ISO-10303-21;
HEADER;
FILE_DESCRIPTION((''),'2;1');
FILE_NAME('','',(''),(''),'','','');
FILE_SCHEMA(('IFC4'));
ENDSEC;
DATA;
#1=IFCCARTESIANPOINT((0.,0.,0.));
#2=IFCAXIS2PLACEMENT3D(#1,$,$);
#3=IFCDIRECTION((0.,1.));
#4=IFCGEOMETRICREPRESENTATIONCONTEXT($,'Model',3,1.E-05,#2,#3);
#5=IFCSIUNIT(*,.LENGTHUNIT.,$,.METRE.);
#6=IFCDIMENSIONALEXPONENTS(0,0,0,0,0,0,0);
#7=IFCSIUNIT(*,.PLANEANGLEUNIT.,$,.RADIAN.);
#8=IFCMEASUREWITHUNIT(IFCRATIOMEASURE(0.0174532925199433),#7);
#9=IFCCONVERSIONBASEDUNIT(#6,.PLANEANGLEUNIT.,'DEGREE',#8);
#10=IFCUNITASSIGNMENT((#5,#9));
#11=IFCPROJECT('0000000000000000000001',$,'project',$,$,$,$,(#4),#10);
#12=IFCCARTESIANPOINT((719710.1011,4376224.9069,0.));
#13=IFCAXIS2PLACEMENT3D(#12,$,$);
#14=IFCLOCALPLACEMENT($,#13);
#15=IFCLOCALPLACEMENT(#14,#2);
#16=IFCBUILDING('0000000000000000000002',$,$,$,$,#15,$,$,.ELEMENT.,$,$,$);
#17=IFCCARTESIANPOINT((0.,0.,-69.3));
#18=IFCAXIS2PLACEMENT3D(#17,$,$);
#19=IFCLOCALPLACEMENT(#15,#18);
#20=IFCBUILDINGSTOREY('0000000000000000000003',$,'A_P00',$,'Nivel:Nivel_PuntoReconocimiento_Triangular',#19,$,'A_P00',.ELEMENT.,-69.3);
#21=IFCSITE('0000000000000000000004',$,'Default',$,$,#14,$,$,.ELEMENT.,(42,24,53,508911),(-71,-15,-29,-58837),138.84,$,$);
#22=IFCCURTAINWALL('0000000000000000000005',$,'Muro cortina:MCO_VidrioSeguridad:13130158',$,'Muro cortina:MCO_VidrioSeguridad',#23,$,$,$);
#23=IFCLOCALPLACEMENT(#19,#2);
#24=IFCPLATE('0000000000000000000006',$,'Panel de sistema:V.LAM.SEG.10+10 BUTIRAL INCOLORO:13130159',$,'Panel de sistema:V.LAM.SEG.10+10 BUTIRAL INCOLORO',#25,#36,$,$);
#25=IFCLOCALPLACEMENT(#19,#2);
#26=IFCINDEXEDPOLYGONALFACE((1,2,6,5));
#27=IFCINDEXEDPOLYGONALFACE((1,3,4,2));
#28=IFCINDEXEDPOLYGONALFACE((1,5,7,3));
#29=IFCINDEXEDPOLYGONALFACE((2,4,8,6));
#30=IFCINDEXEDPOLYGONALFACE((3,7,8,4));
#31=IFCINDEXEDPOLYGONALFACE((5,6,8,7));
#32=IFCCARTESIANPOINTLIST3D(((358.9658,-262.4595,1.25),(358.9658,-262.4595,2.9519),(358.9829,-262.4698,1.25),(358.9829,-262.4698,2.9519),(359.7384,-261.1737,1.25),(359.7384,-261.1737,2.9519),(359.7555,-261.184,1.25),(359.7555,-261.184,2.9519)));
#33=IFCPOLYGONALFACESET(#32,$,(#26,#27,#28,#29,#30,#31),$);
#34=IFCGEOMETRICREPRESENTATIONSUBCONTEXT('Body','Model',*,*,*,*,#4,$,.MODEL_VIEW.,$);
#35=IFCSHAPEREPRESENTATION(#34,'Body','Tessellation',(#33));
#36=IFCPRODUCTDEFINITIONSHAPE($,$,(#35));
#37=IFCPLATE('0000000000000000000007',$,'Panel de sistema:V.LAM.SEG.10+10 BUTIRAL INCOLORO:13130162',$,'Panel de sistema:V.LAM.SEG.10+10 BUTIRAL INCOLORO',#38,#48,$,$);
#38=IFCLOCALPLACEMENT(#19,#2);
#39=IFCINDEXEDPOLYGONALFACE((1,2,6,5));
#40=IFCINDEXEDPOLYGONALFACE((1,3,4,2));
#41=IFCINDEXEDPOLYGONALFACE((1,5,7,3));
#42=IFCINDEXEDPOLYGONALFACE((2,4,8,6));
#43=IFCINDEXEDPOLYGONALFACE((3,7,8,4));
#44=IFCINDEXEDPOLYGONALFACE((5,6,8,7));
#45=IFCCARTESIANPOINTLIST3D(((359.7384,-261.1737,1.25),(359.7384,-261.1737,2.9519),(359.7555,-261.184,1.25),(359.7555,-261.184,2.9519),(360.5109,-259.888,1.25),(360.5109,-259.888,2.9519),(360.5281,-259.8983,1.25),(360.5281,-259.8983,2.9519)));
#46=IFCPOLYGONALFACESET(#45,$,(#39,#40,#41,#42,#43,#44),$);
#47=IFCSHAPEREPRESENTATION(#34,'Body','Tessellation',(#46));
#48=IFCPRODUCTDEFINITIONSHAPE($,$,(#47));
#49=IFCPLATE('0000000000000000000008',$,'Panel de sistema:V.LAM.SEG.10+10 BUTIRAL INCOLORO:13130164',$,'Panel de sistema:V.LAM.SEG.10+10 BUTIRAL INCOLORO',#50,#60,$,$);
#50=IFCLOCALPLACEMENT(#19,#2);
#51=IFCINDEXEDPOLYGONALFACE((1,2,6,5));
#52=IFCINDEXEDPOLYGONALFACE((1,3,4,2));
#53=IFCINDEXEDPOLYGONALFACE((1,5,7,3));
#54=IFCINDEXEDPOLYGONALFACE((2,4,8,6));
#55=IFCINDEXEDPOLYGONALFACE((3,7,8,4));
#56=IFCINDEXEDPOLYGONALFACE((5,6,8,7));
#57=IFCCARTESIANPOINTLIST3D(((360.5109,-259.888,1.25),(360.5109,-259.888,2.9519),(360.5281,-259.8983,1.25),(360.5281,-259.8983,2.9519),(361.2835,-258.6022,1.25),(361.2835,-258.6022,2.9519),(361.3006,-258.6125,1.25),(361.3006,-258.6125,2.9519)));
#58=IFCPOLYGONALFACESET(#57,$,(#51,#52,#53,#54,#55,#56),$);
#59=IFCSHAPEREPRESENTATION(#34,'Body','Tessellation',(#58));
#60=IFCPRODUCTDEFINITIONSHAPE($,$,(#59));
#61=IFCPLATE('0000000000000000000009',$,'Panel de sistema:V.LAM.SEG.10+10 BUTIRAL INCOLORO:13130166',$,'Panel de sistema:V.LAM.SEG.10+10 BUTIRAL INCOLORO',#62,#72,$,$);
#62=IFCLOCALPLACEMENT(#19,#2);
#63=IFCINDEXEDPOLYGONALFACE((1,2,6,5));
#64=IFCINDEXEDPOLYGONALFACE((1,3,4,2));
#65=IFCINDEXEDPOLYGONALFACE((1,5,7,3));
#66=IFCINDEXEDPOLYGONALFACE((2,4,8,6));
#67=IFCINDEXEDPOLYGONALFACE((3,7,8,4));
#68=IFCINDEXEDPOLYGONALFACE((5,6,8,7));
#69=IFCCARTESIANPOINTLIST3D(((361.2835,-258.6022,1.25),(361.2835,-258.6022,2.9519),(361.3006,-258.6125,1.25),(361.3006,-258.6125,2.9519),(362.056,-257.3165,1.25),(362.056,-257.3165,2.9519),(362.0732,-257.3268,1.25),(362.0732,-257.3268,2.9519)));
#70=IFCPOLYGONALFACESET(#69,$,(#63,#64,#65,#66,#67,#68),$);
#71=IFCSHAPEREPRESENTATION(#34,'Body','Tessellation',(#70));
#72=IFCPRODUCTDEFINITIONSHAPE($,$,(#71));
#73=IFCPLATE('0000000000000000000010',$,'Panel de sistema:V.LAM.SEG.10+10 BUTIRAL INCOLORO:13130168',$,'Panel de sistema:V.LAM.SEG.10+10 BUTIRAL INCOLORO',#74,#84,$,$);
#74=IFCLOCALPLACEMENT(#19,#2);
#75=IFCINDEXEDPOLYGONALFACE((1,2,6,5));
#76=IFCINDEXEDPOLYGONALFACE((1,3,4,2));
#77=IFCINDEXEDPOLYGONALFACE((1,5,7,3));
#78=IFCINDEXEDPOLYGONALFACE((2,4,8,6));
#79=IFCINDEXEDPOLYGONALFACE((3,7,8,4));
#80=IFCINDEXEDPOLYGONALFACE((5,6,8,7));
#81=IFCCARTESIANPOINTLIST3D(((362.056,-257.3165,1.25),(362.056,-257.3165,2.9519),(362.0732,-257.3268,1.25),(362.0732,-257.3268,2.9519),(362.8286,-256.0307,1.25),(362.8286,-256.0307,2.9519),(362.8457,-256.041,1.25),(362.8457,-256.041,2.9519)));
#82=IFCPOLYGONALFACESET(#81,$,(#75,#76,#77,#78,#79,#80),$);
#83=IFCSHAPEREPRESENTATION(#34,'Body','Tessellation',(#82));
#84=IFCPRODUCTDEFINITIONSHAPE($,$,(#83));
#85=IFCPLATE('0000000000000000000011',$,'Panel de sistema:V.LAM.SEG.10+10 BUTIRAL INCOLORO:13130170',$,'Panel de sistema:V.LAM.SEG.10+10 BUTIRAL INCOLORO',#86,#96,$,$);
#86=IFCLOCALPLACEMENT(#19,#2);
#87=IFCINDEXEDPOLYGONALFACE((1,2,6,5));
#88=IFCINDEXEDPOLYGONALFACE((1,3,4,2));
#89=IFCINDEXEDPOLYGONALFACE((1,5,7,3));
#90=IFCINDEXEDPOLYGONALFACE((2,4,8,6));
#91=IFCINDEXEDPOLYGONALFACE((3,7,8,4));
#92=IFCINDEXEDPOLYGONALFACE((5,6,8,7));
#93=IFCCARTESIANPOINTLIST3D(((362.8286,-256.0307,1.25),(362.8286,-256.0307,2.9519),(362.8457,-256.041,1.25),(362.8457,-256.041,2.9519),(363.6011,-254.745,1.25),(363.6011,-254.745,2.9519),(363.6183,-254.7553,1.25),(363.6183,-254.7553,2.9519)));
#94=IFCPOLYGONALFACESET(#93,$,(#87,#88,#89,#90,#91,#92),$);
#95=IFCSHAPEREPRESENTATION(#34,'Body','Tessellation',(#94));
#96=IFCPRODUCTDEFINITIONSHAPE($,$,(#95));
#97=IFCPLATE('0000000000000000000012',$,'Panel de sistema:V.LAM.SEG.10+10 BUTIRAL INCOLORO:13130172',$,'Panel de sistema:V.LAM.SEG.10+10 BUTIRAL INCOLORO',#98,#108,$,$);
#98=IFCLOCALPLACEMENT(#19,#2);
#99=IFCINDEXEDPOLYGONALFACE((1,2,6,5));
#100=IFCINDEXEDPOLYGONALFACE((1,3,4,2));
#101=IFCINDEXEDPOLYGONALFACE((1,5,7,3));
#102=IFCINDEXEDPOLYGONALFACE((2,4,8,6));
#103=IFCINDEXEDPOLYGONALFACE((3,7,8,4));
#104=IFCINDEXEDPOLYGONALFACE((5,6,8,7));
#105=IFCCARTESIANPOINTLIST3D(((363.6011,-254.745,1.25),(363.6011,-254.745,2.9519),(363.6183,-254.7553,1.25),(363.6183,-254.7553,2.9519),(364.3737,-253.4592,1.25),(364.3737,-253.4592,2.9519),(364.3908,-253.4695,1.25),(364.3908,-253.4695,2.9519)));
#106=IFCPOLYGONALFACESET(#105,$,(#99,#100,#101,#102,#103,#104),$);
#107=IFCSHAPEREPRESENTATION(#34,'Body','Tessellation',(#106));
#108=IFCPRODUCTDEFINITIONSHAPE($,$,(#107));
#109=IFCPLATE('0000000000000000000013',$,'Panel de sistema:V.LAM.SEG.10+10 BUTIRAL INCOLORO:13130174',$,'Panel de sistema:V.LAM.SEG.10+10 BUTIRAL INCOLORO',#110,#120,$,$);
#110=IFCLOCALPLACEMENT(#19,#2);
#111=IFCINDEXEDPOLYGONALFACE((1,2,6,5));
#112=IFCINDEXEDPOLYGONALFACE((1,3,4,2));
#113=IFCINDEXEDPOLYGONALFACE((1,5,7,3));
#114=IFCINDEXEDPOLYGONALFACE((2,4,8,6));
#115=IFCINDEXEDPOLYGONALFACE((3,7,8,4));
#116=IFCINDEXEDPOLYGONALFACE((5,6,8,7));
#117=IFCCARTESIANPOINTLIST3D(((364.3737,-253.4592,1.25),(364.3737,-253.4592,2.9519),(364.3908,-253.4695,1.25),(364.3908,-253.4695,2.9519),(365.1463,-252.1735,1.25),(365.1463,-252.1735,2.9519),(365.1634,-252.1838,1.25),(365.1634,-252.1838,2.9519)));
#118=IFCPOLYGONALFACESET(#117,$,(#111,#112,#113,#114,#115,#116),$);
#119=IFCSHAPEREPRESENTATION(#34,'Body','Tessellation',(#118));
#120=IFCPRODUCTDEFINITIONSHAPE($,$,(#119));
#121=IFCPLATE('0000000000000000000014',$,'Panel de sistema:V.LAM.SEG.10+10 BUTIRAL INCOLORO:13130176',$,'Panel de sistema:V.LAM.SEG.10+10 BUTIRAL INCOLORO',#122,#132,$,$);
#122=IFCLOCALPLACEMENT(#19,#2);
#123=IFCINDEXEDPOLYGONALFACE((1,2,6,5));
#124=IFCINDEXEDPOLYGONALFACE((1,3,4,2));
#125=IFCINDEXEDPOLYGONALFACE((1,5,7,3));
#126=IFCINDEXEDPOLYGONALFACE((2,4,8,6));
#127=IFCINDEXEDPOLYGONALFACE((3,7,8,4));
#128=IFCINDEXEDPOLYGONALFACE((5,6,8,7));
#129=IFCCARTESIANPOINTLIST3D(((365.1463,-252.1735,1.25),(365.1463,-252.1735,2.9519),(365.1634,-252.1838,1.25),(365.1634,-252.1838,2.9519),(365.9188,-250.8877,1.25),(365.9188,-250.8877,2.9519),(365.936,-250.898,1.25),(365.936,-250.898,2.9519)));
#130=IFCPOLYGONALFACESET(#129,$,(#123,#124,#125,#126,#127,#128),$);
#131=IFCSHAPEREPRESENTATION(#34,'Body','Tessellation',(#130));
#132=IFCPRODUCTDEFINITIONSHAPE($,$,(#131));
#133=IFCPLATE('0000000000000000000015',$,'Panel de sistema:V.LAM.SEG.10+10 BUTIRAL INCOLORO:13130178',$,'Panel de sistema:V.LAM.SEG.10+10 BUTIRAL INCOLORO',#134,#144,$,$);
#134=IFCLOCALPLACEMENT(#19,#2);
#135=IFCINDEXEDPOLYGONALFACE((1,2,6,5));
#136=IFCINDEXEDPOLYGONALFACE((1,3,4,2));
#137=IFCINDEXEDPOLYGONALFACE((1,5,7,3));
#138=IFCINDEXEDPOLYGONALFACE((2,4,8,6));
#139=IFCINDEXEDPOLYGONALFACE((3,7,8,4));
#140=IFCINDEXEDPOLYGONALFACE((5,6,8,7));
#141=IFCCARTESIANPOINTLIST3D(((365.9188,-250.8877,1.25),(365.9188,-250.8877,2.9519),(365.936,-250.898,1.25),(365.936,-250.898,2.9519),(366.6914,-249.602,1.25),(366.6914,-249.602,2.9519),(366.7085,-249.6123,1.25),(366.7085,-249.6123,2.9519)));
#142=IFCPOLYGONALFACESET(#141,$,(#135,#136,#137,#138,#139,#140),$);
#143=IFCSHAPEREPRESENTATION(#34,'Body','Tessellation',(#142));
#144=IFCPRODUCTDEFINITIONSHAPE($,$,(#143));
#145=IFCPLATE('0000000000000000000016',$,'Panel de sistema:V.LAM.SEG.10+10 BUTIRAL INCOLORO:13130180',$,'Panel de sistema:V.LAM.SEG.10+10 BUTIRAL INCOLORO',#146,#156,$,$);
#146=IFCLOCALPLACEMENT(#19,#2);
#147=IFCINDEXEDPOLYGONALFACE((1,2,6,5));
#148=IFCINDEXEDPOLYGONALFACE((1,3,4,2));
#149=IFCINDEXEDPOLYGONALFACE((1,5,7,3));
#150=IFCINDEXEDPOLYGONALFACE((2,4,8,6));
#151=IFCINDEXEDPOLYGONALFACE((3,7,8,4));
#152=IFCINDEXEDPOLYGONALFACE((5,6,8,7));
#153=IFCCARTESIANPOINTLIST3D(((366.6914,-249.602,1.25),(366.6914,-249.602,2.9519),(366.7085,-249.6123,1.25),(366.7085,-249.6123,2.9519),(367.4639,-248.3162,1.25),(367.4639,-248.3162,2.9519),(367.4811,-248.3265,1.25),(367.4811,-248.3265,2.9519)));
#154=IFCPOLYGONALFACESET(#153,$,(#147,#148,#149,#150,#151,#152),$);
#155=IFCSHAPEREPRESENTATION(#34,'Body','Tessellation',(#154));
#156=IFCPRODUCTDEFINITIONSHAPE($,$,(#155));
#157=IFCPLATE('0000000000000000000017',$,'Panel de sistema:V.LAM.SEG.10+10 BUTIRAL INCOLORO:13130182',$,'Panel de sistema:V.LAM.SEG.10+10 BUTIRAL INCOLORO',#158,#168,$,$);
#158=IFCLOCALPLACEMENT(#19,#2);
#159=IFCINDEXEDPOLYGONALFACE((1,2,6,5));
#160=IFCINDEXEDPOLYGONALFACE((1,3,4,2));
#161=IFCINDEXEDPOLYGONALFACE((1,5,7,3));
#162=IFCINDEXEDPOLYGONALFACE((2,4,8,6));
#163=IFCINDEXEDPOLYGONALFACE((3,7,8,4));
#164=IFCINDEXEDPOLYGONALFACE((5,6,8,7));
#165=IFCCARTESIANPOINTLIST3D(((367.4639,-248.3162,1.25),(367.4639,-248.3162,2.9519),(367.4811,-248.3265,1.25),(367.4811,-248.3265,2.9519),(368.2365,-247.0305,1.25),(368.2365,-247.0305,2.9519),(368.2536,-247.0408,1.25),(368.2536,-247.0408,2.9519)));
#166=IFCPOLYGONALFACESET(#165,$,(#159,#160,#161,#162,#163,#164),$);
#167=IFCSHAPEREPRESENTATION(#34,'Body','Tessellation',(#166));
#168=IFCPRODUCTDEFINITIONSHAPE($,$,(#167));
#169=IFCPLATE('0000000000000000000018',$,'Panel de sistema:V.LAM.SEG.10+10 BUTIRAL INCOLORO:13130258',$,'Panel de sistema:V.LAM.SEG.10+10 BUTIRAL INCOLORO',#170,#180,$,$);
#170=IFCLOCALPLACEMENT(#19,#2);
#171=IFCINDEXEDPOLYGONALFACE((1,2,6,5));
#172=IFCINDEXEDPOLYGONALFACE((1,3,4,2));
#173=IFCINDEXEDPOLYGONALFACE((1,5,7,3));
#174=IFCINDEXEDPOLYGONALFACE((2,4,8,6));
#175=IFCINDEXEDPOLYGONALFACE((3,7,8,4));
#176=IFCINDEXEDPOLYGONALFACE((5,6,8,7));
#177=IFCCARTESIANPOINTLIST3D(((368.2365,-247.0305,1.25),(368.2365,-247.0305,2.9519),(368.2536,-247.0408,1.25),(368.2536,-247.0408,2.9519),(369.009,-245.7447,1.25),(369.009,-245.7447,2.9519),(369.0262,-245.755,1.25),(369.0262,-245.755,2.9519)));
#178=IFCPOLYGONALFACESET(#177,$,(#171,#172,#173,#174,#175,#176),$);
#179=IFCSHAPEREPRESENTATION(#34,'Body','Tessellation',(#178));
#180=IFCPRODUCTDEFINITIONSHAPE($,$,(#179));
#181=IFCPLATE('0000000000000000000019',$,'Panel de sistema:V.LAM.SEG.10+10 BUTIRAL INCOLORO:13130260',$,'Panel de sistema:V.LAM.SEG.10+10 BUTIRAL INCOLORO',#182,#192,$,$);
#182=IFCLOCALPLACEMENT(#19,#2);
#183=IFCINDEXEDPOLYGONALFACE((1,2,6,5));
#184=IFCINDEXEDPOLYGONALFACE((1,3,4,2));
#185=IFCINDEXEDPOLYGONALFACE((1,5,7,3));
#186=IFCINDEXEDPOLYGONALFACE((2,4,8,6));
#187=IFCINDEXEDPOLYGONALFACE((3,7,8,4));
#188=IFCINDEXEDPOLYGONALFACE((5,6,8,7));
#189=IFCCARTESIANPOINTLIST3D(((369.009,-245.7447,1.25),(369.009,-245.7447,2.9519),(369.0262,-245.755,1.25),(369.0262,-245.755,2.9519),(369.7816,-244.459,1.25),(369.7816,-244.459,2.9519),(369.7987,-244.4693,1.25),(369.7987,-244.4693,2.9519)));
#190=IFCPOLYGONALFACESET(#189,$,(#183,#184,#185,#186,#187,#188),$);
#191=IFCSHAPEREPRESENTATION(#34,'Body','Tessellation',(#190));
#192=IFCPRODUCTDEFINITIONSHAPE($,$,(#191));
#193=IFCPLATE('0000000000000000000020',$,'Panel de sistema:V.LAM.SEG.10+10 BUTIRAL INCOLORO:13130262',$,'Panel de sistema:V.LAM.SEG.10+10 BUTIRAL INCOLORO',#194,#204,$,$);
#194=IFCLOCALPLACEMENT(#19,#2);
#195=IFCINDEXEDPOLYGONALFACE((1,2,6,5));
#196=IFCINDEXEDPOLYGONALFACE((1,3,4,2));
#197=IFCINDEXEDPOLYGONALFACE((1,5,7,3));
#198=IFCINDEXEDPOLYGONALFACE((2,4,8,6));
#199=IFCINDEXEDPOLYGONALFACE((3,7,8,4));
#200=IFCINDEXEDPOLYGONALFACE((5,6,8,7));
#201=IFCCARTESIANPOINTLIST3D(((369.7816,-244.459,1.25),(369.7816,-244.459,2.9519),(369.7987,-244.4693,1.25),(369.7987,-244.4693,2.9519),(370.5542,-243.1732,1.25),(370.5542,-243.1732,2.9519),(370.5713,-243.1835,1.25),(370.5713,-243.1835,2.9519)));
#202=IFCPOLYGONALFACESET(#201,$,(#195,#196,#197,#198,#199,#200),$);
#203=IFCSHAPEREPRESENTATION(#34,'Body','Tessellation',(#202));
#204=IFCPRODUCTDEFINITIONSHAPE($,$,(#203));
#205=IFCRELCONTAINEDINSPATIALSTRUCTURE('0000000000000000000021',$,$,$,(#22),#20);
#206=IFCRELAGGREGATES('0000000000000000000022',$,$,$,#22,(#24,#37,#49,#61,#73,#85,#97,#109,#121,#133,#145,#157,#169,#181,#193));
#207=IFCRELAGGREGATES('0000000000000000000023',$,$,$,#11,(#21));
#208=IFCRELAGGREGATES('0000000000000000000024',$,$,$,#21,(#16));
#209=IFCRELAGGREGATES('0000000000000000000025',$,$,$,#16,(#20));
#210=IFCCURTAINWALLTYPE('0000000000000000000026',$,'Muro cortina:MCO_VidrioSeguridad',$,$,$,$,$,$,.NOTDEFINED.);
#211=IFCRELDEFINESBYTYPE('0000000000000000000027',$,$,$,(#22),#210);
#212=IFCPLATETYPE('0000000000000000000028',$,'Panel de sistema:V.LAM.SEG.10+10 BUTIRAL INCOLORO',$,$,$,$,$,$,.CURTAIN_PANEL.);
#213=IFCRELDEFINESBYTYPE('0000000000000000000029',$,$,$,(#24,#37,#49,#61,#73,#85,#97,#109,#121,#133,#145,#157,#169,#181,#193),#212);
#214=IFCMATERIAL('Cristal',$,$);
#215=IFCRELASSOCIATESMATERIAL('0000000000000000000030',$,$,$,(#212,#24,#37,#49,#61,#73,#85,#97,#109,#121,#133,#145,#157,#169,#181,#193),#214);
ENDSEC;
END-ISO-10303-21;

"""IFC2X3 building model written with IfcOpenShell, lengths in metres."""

from ifc_helpers import new_model, entity, si_unit, converted_unit, direction, frame, frame_2d, origin, place, context, subcontext, project, spatial, rectangle, extrude, source, transform, mapped, material, type_object, type_shapes, element, aggregate, save


model = new_model("IFC2X3")

# Units and contexts
model_context = context("Model", 3, precision=1e-05, world=origin(), true_north=direction((0.0, 1.0)))
body_context = subcontext(model_context, "Body", "Model", "MODEL_VIEW")
ifc_project = project(units=[si_unit("LENGTHUNIT", "METRE"), converted_unit("PLANEANGLEUNIT", "DEGREE", entity("IfcRatioMeasure", 0.0174532925199433), si_unit("PLANEANGLEUNIT", "RADIAN"), dimensions=[0, 0, 0, 0, 0, 0, 0])], contexts=[model_context])

# Site, building, storey
site_placement = place(None, frame((719710.1011, 4376224.9069, 0.0)))
site = spatial("IfcSite", under=ifc_project, at=site_placement, Name="Default", CompositionType="ELEMENT", RefLatitude=(42, 24, 53, 508911), RefLongitude=(-71, -15, -29, -58837), RefElevation=138.84)
building_placement = place(site_placement, origin())
building = spatial("IfcBuilding", under=site, at=building_placement, CompositionType="ELEMENT")
storey_placement = place(building_placement, frame((0.0, 0.0, -69.3)))
storey = spatial("IfcBuildingStorey", under=building, at=storey_placement, Name="A_P00", ObjectType="Nivel:Nivel_PuntoReconocimiento_Triangular", LongName="A_P00", CompositionType="ELEMENT", Elevation=-69.3)

# Curtain wall, plates
curtain_wall_type = type_object("IfcCurtainWallType", Name="Muro cortina:MCO_VidrioSeguridad", PredefinedType="NOTDEFINED")
curtain_wall_placement = place(storey_placement, frame((0.0, 0.0, 69.3)))
curtain_wall = element("IfcCurtainWall", 1, at=curtain_wall_placement, inside=storey, type_object=curtain_wall_type, Name="Muro cortina:MCO_VidrioSeguridad:13130158", ObjectType="Muro cortina:MCO_VidrioSeguridad")
ifc_material_1 = material(Name="Cristal")
plate_type = type_object("IfcPlateType", Name="Panel de sistema:V.LAM.SEG.10+10 BUTIRAL INCOLORO", PredefinedType="CURTAIN_PANEL", material=ifc_material_1)
shared_shape = source(origin(), body_context, "Body", "SweptSolid", [
    extrude(rectangle(XDim=0.02, YDim=1.5, at=frame_2d((0.0, 0.0), x_axis=(1.0, 0.0))), frame((0.0, 0.0, 0.0), z_axis=(0.0, 0.0, 1.0), x_axis=(0.0, 1.0, 0.0)), (0.0, 0.0, 1.0), 1.7019),
])
type_shapes(plate_type, [shared_shape])
plate_1_placement = place(curtain_wall_placement, frame((359.3606, -261.8217, -68.05), z_axis=(0.0, 0.0, 1.0), x_axis=(0.515038, 0.857167, 0.0)))
plate_1 = element("IfcPlate", 2, at=plate_1_placement, type_object=plate_type, material=ifc_material_1, Name="Panel de sistema:V.LAM.SEG.10+10 BUTIRAL INCOLORO:13130159", ObjectType="Panel de sistema:V.LAM.SEG.10+10 BUTIRAL INCOLORO", context=body_context, shape_type="MappedRepresentation", body=[
    mapped(shared_shape, transform((0.0, 0.0, 0.0), scale=1.0)),
])
plate_2_placement = place(curtain_wall_placement, frame((360.1332, -260.536, -68.05), z_axis=(0.0, 0.0, 1.0), x_axis=(0.515038, 0.857167, 0.0)))
plate_2 = element("IfcPlate", 3, at=plate_2_placement, type_object=plate_type, material=ifc_material_1, Name="Panel de sistema:V.LAM.SEG.10+10 BUTIRAL INCOLORO:13130162", ObjectType="Panel de sistema:V.LAM.SEG.10+10 BUTIRAL INCOLORO", context=body_context, shape_type="MappedRepresentation", body=[
    mapped(shared_shape, transform((0.0, 0.0, 0.0), scale=1.0)),
])
plate_3_placement = place(curtain_wall_placement, frame((360.9058, -259.2502, -68.05), z_axis=(0.0, 0.0, 1.0), x_axis=(0.515038, 0.857167, 0.0)))
plate_3 = element("IfcPlate", 4, at=plate_3_placement, type_object=plate_type, material=ifc_material_1, Name="Panel de sistema:V.LAM.SEG.10+10 BUTIRAL INCOLORO:13130164", ObjectType="Panel de sistema:V.LAM.SEG.10+10 BUTIRAL INCOLORO", context=body_context, shape_type="MappedRepresentation", body=[
    mapped(shared_shape, transform((0.0, 0.0, 0.0), scale=1.0)),
])
plate_4_placement = place(curtain_wall_placement, frame((361.6783, -257.9645, -68.05), z_axis=(0.0, 0.0, 1.0), x_axis=(0.515038, 0.857167, 0.0)))
plate_4 = element("IfcPlate", 5, at=plate_4_placement, type_object=plate_type, material=ifc_material_1, Name="Panel de sistema:V.LAM.SEG.10+10 BUTIRAL INCOLORO:13130166", ObjectType="Panel de sistema:V.LAM.SEG.10+10 BUTIRAL INCOLORO", context=body_context, shape_type="MappedRepresentation", body=[
    mapped(shared_shape, transform((0.0, 0.0, 0.0), scale=1.0)),
])
plate_5_placement = place(curtain_wall_placement, frame((362.4509, -256.6787, -68.05), z_axis=(0.0, 0.0, 1.0), x_axis=(0.515038, 0.857167, 0.0)))
plate_5 = element("IfcPlate", 6, at=plate_5_placement, type_object=plate_type, material=ifc_material_1, Name="Panel de sistema:V.LAM.SEG.10+10 BUTIRAL INCOLORO:13130168", ObjectType="Panel de sistema:V.LAM.SEG.10+10 BUTIRAL INCOLORO", context=body_context, shape_type="MappedRepresentation", body=[
    mapped(shared_shape, transform((0.0, 0.0, 0.0), scale=1.0)),
])
plate_6_placement = place(curtain_wall_placement, frame((363.2234, -255.393, -68.05), z_axis=(0.0, 0.0, 1.0), x_axis=(0.515038, 0.857167, 0.0)))
plate_6 = element("IfcPlate", 7, at=plate_6_placement, type_object=plate_type, material=ifc_material_1, Name="Panel de sistema:V.LAM.SEG.10+10 BUTIRAL INCOLORO:13130170", ObjectType="Panel de sistema:V.LAM.SEG.10+10 BUTIRAL INCOLORO", context=body_context, shape_type="MappedRepresentation", body=[
    mapped(shared_shape, transform((0.0, 0.0, 0.0), scale=1.0)),
])
plate_7_placement = place(curtain_wall_placement, frame((363.996, -254.1072, -68.05), z_axis=(0.0, 0.0, 1.0), x_axis=(0.515038, 0.857167, 0.0)))
plate_7 = element("IfcPlate", 8, at=plate_7_placement, type_object=plate_type, material=ifc_material_1, Name="Panel de sistema:V.LAM.SEG.10+10 BUTIRAL INCOLORO:13130172", ObjectType="Panel de sistema:V.LAM.SEG.10+10 BUTIRAL INCOLORO", context=body_context, shape_type="MappedRepresentation", body=[
    mapped(shared_shape, transform((0.0, 0.0, 0.0), scale=1.0)),
])
plate_8_placement = place(curtain_wall_placement, frame((364.7685, -252.8215, -68.05), z_axis=(0.0, 0.0, 1.0), x_axis=(0.515038, 0.857167, 0.0)))
plate_8 = element("IfcPlate", 9, at=plate_8_placement, type_object=plate_type, material=ifc_material_1, Name="Panel de sistema:V.LAM.SEG.10+10 BUTIRAL INCOLORO:13130174", ObjectType="Panel de sistema:V.LAM.SEG.10+10 BUTIRAL INCOLORO", context=body_context, shape_type="MappedRepresentation", body=[
    mapped(shared_shape, transform((0.0, 0.0, 0.0), scale=1.0)),
])
plate_9_placement = place(curtain_wall_placement, frame((365.5411, -251.5357, -68.05), z_axis=(0.0, 0.0, 1.0), x_axis=(0.515038, 0.857167, 0.0)))
plate_9 = element("IfcPlate", 10, at=plate_9_placement, type_object=plate_type, material=ifc_material_1, Name="Panel de sistema:V.LAM.SEG.10+10 BUTIRAL INCOLORO:13130176", ObjectType="Panel de sistema:V.LAM.SEG.10+10 BUTIRAL INCOLORO", context=body_context, shape_type="MappedRepresentation", body=[
    mapped(shared_shape, transform((0.0, 0.0, 0.0), scale=1.0)),
])
plate_10_placement = place(curtain_wall_placement, frame((366.3137, -250.25, -68.05), z_axis=(0.0, 0.0, 1.0), x_axis=(0.515038, 0.857167, 0.0)))
plate_10 = element("IfcPlate", 11, at=plate_10_placement, type_object=plate_type, material=ifc_material_1, Name="Panel de sistema:V.LAM.SEG.10+10 BUTIRAL INCOLORO:13130178", ObjectType="Panel de sistema:V.LAM.SEG.10+10 BUTIRAL INCOLORO", context=body_context, shape_type="MappedRepresentation", body=[
    mapped(shared_shape, transform((0.0, 0.0, 0.0), scale=1.0)),
])
plate_11_placement = place(curtain_wall_placement, frame((367.0862, -248.9642, -68.05), z_axis=(0.0, 0.0, 1.0), x_axis=(0.515038, 0.857167, 0.0)))
plate_11 = element("IfcPlate", 12, at=plate_11_placement, type_object=plate_type, material=ifc_material_1, Name="Panel de sistema:V.LAM.SEG.10+10 BUTIRAL INCOLORO:13130180", ObjectType="Panel de sistema:V.LAM.SEG.10+10 BUTIRAL INCOLORO", context=body_context, shape_type="MappedRepresentation", body=[
    mapped(shared_shape, transform((0.0, 0.0, 0.0), scale=1.0)),
])
plate_12_placement = place(curtain_wall_placement, frame((367.8588, -247.6785, -68.05), z_axis=(0.0, 0.0, 1.0), x_axis=(0.515038, 0.857167, 0.0)))
plate_12 = element("IfcPlate", 13, at=plate_12_placement, type_object=plate_type, material=ifc_material_1, Name="Panel de sistema:V.LAM.SEG.10+10 BUTIRAL INCOLORO:13130182", ObjectType="Panel de sistema:V.LAM.SEG.10+10 BUTIRAL INCOLORO", context=body_context, shape_type="MappedRepresentation", body=[
    mapped(shared_shape, transform((0.0, 0.0, 0.0), scale=1.0)),
])
plate_13_placement = place(curtain_wall_placement, frame((368.6313, -246.3927, -68.05), z_axis=(0.0, 0.0, 1.0), x_axis=(0.515038, 0.857167, 0.0)))
plate_13 = element("IfcPlate", 14, at=plate_13_placement, type_object=plate_type, material=ifc_material_1, Name="Panel de sistema:V.LAM.SEG.10+10 BUTIRAL INCOLORO:13130258", ObjectType="Panel de sistema:V.LAM.SEG.10+10 BUTIRAL INCOLORO", context=body_context, shape_type="MappedRepresentation", body=[
    mapped(shared_shape, transform((0.0, 0.0, 0.0), scale=1.0)),
])
plate_14_placement = place(curtain_wall_placement, frame((369.4039, -245.107, -68.05), z_axis=(0.0, 0.0, 1.0), x_axis=(0.515038, 0.857167, 0.0)))
plate_14 = element("IfcPlate", 15, at=plate_14_placement, type_object=plate_type, material=ifc_material_1, Name="Panel de sistema:V.LAM.SEG.10+10 BUTIRAL INCOLORO:13130260", ObjectType="Panel de sistema:V.LAM.SEG.10+10 BUTIRAL INCOLORO", context=body_context, shape_type="MappedRepresentation", body=[
    mapped(shared_shape, transform((0.0, 0.0, 0.0), scale=1.0)),
])
plate_15_placement = place(curtain_wall_placement, frame((370.1764, -243.8212, -68.05), z_axis=(0.0, 0.0, 1.0), x_axis=(0.515038, 0.857167, 0.0)))
plate_15 = element("IfcPlate", 16, at=plate_15_placement, type_object=plate_type, material=ifc_material_1, Name="Panel de sistema:V.LAM.SEG.10+10 BUTIRAL INCOLORO:13130262", ObjectType="Panel de sistema:V.LAM.SEG.10+10 BUTIRAL INCOLORO", context=body_context, shape_type="MappedRepresentation", body=[
    mapped(shared_shape, transform((0.0, 0.0, 0.0), scale=1.0)),
])
aggregate(curtain_wall, [plate_1, plate_2, plate_3, plate_4, plate_5, plate_6, plate_7, plate_8, plate_9, plate_10, plate_11, plate_12, plate_13, plate_14, plate_15])

save(model, "model.ifc")
